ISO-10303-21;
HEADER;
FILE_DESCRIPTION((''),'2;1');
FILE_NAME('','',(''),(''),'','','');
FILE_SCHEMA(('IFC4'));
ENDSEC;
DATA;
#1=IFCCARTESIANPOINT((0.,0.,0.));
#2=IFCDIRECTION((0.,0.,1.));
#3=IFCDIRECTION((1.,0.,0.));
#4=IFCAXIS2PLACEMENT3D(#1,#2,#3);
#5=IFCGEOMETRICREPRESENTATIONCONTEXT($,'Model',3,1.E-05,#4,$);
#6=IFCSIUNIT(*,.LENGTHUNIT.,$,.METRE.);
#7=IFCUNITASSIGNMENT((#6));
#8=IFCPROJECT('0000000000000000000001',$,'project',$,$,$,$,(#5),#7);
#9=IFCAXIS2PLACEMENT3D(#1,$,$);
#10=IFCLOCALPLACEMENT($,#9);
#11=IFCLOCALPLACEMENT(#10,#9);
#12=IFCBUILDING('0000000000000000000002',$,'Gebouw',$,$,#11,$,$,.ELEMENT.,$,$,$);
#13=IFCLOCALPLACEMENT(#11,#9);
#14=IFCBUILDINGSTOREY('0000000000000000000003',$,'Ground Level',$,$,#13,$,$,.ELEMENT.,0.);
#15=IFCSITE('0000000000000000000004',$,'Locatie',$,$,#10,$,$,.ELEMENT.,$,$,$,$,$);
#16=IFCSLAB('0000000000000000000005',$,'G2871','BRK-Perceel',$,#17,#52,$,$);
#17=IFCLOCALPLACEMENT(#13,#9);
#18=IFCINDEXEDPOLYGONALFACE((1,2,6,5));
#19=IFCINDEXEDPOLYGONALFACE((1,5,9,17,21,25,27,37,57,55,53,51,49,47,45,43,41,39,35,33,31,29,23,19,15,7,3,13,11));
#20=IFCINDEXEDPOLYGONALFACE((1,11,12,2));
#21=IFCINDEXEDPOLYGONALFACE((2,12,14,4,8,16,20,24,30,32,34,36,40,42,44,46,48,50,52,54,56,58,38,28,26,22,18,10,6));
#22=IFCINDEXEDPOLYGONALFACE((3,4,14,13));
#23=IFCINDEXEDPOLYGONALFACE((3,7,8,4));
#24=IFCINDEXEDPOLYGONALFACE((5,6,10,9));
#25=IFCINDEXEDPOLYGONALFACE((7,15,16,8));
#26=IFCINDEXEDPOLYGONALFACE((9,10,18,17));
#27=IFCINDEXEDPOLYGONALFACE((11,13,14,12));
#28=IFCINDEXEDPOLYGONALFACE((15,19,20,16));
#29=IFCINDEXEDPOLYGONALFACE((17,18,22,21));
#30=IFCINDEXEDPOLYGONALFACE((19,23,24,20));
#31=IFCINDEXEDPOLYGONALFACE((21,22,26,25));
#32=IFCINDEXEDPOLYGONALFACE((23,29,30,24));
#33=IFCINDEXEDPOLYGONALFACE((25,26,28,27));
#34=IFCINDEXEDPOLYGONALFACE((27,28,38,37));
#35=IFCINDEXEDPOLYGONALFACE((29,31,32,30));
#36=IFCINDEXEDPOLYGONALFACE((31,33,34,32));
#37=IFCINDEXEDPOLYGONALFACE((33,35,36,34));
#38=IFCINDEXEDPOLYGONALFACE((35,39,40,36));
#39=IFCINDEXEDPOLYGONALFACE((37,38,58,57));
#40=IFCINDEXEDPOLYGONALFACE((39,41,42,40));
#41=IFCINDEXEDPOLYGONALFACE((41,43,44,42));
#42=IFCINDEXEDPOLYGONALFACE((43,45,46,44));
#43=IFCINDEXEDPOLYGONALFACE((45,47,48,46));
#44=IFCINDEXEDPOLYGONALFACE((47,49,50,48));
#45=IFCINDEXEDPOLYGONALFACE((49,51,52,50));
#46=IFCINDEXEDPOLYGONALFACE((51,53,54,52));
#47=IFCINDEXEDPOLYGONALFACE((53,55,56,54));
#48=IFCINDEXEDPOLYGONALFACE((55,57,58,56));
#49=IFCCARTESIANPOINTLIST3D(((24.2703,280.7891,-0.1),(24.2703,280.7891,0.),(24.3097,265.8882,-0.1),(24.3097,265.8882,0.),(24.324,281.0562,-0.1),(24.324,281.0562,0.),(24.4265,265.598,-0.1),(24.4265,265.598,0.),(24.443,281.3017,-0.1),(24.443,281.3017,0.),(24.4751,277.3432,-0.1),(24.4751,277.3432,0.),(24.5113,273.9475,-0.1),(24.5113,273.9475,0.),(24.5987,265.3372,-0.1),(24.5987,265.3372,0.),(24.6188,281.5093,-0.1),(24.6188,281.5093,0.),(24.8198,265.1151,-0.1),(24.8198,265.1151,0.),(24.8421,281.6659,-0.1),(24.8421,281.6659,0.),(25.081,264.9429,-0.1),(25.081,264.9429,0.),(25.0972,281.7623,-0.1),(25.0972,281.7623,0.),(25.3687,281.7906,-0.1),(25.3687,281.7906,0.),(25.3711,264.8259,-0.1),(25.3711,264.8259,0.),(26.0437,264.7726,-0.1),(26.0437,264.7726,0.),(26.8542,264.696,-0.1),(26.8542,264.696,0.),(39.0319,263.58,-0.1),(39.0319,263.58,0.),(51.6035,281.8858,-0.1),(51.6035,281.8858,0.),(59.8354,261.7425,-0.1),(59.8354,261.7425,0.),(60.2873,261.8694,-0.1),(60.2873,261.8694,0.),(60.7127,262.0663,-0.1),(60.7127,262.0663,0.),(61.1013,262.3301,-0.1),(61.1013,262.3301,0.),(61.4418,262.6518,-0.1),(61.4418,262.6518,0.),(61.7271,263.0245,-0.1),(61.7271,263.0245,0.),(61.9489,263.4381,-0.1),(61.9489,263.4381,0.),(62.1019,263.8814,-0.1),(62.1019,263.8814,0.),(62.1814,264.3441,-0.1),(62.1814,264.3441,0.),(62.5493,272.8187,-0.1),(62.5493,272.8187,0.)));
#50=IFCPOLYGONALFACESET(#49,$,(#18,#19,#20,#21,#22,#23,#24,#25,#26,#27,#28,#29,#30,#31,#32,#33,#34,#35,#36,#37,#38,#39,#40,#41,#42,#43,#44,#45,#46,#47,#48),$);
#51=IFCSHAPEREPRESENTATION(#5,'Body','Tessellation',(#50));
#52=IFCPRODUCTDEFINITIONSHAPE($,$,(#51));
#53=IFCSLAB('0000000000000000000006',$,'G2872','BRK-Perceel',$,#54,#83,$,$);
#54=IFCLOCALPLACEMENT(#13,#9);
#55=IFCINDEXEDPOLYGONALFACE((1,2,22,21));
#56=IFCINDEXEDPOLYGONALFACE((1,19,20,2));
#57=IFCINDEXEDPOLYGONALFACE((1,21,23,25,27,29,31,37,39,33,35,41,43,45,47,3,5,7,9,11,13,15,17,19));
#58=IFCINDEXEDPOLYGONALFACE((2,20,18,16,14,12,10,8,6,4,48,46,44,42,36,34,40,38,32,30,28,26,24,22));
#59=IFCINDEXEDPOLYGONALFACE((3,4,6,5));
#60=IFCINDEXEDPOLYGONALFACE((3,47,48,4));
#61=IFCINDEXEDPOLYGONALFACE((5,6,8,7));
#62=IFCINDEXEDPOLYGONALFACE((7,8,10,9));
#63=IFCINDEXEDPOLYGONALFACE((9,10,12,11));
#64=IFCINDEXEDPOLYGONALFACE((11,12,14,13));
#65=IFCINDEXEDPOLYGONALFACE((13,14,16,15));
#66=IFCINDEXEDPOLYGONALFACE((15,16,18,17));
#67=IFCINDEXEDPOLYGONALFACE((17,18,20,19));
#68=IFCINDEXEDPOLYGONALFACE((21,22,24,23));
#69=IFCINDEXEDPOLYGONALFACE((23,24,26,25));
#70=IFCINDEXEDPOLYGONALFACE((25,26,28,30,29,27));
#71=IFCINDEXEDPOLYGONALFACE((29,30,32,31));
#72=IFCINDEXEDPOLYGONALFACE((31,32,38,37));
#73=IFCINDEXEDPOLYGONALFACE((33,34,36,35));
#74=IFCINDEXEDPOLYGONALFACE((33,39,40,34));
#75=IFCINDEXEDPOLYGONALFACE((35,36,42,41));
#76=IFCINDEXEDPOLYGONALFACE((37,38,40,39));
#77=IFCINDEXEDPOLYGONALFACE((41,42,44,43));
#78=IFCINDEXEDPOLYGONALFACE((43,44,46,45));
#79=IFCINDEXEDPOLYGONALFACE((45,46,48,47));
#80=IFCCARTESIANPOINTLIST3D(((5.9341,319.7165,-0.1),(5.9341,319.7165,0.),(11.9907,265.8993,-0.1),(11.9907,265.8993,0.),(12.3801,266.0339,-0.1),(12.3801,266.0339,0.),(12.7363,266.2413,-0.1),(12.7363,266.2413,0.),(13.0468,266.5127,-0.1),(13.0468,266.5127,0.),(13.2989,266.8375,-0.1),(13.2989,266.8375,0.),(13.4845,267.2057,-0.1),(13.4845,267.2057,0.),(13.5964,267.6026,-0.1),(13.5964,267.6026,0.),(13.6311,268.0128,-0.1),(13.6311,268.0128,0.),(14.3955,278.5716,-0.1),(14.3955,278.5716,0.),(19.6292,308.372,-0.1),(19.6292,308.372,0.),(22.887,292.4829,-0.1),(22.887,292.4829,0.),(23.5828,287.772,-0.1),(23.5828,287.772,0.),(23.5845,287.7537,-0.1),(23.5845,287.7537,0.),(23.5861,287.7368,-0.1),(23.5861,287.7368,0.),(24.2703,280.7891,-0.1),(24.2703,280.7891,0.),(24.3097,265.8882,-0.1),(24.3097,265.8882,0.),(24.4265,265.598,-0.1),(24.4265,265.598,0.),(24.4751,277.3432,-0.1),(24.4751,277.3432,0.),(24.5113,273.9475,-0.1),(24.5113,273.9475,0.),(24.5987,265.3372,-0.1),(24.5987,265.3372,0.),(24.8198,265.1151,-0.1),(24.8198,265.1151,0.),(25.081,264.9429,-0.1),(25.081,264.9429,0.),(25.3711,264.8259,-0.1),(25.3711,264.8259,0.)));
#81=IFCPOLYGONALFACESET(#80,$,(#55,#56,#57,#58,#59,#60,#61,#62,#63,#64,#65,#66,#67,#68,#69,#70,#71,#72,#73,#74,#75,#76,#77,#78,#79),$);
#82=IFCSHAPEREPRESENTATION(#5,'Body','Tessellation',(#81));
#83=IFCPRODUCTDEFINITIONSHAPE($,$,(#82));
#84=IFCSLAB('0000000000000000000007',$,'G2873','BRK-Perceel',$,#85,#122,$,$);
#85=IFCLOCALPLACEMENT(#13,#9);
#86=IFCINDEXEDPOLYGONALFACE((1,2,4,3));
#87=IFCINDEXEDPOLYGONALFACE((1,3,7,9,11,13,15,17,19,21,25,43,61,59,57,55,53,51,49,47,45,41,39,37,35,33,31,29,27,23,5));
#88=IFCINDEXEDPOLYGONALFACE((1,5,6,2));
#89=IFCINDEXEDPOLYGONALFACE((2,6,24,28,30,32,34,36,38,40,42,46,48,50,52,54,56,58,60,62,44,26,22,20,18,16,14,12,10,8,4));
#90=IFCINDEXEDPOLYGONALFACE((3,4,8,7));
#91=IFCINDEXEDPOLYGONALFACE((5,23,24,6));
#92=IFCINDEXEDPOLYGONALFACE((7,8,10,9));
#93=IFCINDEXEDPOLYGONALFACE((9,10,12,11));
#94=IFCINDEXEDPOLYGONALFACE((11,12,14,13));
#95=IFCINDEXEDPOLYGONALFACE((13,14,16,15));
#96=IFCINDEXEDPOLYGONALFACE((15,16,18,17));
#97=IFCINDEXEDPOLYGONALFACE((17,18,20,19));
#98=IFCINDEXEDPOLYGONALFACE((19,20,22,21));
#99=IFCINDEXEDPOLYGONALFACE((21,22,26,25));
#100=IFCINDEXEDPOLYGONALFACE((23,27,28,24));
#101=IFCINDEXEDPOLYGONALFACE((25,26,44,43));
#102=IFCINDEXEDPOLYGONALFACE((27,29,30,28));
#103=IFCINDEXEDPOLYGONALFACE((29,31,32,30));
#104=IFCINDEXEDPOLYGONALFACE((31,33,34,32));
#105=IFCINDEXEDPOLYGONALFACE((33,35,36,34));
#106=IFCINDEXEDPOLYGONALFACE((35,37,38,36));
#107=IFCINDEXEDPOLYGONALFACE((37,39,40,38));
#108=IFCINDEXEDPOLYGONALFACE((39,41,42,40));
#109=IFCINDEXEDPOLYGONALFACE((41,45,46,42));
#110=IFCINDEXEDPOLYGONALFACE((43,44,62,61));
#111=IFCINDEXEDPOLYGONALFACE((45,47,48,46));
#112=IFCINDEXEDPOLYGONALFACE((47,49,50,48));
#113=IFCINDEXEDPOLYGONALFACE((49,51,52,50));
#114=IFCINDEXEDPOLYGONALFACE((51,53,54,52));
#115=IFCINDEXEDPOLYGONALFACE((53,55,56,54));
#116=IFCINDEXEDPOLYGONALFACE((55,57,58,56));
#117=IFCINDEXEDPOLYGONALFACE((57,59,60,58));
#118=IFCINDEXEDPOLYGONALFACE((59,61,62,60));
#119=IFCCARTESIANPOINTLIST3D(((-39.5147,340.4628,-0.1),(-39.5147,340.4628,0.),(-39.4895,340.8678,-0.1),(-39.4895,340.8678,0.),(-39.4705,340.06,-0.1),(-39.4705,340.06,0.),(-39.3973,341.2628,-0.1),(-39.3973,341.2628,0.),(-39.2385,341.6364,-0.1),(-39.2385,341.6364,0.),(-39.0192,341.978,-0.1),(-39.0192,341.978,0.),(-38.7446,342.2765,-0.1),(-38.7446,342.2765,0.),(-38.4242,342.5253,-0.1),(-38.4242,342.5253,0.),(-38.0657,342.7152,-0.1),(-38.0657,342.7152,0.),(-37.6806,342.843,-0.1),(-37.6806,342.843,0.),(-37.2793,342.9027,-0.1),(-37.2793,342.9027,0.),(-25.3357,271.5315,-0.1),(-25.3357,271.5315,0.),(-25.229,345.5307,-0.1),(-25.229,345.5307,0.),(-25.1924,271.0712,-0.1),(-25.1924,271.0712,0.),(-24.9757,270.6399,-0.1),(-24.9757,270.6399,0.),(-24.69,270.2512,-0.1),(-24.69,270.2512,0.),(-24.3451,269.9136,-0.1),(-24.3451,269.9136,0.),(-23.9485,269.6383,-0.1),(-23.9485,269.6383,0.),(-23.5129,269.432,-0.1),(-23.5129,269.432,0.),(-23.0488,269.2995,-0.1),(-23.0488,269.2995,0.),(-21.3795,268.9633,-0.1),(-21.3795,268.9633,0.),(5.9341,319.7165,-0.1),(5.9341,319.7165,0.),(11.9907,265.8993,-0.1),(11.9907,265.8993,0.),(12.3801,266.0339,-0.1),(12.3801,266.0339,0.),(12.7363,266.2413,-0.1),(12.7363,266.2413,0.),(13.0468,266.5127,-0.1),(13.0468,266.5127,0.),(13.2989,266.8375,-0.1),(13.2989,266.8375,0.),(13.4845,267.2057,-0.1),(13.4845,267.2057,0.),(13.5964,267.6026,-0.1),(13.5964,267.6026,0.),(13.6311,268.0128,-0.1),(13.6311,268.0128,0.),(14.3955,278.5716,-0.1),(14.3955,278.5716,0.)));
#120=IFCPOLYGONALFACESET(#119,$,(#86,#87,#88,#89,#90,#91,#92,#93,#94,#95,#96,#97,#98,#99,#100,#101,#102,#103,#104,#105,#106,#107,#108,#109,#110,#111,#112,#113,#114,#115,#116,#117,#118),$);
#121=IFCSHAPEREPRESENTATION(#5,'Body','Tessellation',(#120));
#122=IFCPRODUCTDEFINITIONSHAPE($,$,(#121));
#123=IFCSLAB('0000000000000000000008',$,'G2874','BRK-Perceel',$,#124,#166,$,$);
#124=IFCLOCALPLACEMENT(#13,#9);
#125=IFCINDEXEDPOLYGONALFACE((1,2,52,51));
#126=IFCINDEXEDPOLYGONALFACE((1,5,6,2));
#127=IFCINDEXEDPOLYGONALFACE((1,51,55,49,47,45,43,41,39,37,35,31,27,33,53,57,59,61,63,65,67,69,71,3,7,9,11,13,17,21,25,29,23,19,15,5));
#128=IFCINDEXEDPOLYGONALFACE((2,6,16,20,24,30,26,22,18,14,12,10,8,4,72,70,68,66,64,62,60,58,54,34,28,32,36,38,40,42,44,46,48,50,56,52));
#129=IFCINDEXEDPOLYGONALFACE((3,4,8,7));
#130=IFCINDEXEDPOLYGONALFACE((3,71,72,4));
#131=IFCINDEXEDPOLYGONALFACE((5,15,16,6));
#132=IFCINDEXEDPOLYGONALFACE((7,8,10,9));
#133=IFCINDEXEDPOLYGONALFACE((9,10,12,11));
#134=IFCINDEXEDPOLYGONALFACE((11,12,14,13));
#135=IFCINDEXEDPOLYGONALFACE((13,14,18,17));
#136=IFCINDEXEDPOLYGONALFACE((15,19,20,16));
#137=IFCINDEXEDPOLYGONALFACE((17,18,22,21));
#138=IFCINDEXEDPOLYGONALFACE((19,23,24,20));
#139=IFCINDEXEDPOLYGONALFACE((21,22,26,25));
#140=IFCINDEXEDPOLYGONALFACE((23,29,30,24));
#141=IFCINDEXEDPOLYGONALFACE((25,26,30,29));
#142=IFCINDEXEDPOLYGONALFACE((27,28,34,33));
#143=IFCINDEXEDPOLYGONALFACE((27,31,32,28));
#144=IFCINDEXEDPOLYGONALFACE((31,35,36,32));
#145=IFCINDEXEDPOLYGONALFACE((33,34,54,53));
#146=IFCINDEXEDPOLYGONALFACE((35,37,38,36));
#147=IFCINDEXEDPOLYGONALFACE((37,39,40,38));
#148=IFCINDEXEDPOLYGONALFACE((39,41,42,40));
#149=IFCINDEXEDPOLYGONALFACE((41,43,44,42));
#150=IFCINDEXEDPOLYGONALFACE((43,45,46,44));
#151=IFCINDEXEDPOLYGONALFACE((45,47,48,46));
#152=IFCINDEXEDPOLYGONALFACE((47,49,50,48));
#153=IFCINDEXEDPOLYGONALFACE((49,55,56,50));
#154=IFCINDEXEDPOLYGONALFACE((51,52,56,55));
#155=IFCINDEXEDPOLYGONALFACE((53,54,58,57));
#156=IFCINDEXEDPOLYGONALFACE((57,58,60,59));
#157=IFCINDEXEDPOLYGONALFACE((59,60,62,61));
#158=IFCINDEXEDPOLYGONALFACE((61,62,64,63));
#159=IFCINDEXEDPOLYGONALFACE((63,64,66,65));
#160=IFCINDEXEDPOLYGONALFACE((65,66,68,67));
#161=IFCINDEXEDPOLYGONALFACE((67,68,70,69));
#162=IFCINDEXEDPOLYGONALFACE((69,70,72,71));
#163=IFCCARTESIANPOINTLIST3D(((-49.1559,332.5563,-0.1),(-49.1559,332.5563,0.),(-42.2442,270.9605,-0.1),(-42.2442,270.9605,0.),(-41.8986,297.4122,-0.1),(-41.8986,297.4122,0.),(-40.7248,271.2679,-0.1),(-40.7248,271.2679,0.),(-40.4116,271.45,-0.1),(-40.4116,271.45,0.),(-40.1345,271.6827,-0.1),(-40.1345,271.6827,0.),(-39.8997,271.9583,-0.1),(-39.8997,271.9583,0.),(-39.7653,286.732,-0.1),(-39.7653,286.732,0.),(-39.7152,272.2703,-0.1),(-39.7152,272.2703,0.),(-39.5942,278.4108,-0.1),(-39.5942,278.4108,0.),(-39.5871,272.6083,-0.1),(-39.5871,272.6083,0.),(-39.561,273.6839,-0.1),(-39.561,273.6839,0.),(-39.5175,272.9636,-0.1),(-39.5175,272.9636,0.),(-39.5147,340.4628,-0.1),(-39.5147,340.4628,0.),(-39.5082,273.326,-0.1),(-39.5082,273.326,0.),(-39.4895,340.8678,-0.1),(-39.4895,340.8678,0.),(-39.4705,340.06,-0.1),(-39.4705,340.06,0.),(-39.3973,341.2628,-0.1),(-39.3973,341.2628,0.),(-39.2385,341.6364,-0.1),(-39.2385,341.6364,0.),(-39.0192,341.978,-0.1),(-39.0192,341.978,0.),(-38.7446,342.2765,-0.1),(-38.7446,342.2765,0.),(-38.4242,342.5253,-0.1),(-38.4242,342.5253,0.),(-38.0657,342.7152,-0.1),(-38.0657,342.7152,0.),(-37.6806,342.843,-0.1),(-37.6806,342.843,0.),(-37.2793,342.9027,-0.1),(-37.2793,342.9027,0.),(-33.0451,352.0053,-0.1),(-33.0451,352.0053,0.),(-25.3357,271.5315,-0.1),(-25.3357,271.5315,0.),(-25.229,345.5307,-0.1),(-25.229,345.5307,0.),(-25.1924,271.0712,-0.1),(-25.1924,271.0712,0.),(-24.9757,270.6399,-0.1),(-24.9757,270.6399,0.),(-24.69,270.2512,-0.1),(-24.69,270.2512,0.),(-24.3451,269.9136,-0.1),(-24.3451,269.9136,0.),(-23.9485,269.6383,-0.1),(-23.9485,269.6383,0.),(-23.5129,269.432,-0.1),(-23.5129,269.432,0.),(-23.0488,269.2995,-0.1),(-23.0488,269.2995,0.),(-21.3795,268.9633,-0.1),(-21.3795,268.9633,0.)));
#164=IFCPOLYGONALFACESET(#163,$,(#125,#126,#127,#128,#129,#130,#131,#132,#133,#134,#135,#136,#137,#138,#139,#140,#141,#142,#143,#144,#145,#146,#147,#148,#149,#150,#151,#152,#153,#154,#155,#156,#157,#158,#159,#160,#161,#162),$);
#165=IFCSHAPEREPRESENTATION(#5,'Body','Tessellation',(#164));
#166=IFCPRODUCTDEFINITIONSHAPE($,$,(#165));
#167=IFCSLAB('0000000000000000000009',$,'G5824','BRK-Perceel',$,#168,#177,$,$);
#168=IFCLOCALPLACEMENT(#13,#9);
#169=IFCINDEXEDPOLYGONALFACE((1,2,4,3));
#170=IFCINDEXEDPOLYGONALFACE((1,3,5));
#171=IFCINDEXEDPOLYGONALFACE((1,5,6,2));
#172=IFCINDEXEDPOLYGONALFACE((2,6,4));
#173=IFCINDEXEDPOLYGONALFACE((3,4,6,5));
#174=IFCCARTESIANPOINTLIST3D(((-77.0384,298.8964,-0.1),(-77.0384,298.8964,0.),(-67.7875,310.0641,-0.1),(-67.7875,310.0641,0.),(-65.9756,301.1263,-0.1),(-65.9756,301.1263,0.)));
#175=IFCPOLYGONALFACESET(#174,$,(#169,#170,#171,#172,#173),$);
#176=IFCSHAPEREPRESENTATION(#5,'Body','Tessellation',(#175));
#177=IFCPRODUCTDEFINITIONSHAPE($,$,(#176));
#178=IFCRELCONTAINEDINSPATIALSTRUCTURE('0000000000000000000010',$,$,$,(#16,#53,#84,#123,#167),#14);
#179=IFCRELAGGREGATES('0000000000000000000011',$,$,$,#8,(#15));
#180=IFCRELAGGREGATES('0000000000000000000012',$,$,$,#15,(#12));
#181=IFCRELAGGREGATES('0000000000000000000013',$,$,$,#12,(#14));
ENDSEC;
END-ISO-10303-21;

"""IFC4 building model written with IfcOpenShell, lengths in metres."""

from ifc_helpers import new_model, si_unit, frame, origin, origin_with_axes, place, context, project, spatial, polyline, outline, extrude, element, save


model = new_model("IFC4")

# Units and contexts
model_context = context("Model", 3, precision=1e-05, world=origin_with_axes())
ifc_project = project(units=[si_unit("LENGTHUNIT", "METRE")], contexts=[model_context])

# Site, building, storey
site_placement = place(None, origin())
site = spatial("IfcSite", under=ifc_project, at=site_placement, Name="Locatie", CompositionType="ELEMENT")
building_placement = place(site_placement, origin())
building = spatial("IfcBuilding", under=site, at=building_placement, Name="Gebouw", CompositionType="ELEMENT")
storey_placement = place(building_placement, origin())
storey = spatial("IfcBuildingStorey", under=building, at=storey_placement, Name="Ground Level", CompositionType="ELEMENT", Elevation=0.0)

# Slabs
slab_1_placement = place(storey_placement, origin())
element("IfcSlab", 1, at=slab_1_placement, inside=storey, Name="G2871", Description="BRK-Perceel", context=model_context, shape_type="SweptSolid", body=[
    extrude(outline(polyline([(62.1814, 264.3441), (62.1019, 263.8814), (61.9489, 263.4381), (61.7271, 263.0245), (61.4418, 262.6518), (61.1013, 262.3301), (60.7127, 262.0663), (60.2873, 261.8694), (59.8354, 261.7425), (39.0319, 263.58), (26.8542, 264.696), (26.0437, 264.7726), (25.3711, 264.8259), (25.081, 264.9429), (24.8198, 265.1151), (24.5987, 265.3372), (24.4265, 265.598), (24.3097, 265.8882), (24.5113, 273.9475), (24.4751, 277.3432), (24.2703, 280.7891), (24.324, 281.0562), (24.443, 281.3017), (24.6188, 281.5093), (24.8421, 281.6659), (25.0972, 281.7623), (25.3687, 281.7906), (51.6035, 281.8858), (62.5493, 272.8187), (62.1814, 264.3441)])), frame((0.0, 0.0, -0.1), z_axis=(0.0, 0.0, 1.0), x_axis=(1.0, 0.0, 0.0)), (0.0, 0.0, 1.0), 0.1),
])
slab_2_placement = place(storey_placement, origin())
element("IfcSlab", 2, at=slab_2_placement, inside=storey, Name="G2872", Description="BRK-Perceel", context=model_context, shape_type="SweptSolid", body=[
    extrude(outline(polyline([(22.887, 292.4829), (23.5828, 287.772), (23.5845, 287.7537), (23.5861, 287.7368), (24.2703, 280.7891), (24.4751, 277.3432), (24.5113, 273.9475), (24.3097, 265.8882), (24.4265, 265.598), (24.5987, 265.3372), (24.8198, 265.1151), (25.081, 264.9429), (25.3711, 264.8259), (11.9907, 265.8993), (12.3801, 266.0339), (12.7363, 266.2413), (13.0468, 266.5127), (13.2989, 266.8375), (13.4845, 267.2057), (13.5964, 267.6026), (13.6311, 268.0128), (14.3955, 278.5716), (5.9341, 319.7165), (19.6292, 308.372), (22.887, 292.4829)])), frame((0.0, 0.0, -0.1), z_axis=(0.0, 0.0, 1.0), x_axis=(1.0, 0.0, 0.0)), (0.0, 0.0, 1.0), 0.1),
])
slab_3_placement = place(storey_placement, origin())
element("IfcSlab", 3, at=slab_3_placement, inside=storey, Name="G2873", Description="BRK-Perceel", context=model_context, shape_type="SweptSolid", body=[
    extrude(outline(polyline([(14.3955, 278.5716), (13.6311, 268.0128), (13.5964, 267.6026), (13.4845, 267.2057), (13.2989, 266.8375), (13.0468, 266.5127), (12.7363, 266.2413), (12.3801, 266.0339), (11.9907, 265.8993), (-21.3795, 268.9633), (-23.0488, 269.2995), (-23.5129, 269.432), (-23.9485, 269.6383), (-24.3451, 269.9136), (-24.69, 270.2512), (-24.9757, 270.6399), (-25.1924, 271.0712), (-25.3357, 271.5315), (-39.4705, 340.06), (-39.5147, 340.4628), (-39.4895, 340.8678), (-39.3973, 341.2628), (-39.2385, 341.6364), (-39.0192, 341.978), (-38.7446, 342.2765), (-38.4242, 342.5253), (-38.0657, 342.7152), (-37.6806, 342.843), (-37.2793, 342.9027), (-25.229, 345.5307), (5.9341, 319.7165), (14.3955, 278.5716)])), frame((0.0, 0.0, -0.1), z_axis=(0.0, 0.0, 1.0), x_axis=(1.0, 0.0, 0.0)), (0.0, 0.0, 1.0), 0.1),
])
slab_4_placement = place(storey_placement, origin())
element("IfcSlab", 4, at=slab_4_placement, inside=storey, Name="G2874", Description="BRK-Perceel", context=model_context, shape_type="SweptSolid", body=[
    extrude(outline(polyline([(-37.2793, 342.9027), (-37.6806, 342.843), (-38.0657, 342.7152), (-38.4242, 342.5253), (-38.7446, 342.2765), (-39.0192, 341.978), (-39.2385, 341.6364), (-39.3973, 341.2628), (-39.4895, 340.8678), (-39.5147, 340.4628), (-39.4705, 340.06), (-25.3357, 271.5315), (-25.1924, 271.0712), (-24.9757, 270.6399), (-24.69, 270.2512), (-24.3451, 269.9136), (-23.9485, 269.6383), (-23.5129, 269.432), (-23.0488, 269.2995), (-21.3795, 268.9633), (-42.2442, 270.9605), (-40.7248, 271.2679), (-40.4116, 271.45), (-40.1345, 271.6827), (-39.8997, 271.9583), (-39.7152, 272.2703), (-39.5871, 272.6083), (-39.5175, 272.9636), (-39.5082, 273.326), (-39.561, 273.6839), (-39.5942, 278.4108), (-39.7653, 286.732), (-41.8986, 297.4122), (-49.1559, 332.5563), (-33.0451, 352.0053), (-25.229, 345.5307), (-37.2793, 342.9027)])), frame((0.0, 0.0, -0.1), z_axis=(0.0, 0.0, 1.0), x_axis=(1.0, 0.0, 0.0)), (0.0, 0.0, 1.0), 0.1),
])
slab_5_placement = place(storey_placement, origin())
element("IfcSlab", 5, at=slab_5_placement, inside=storey, Name="G5824", Description="BRK-Perceel", context=model_context, shape_type="SweptSolid", body=[
    extrude(outline(polyline([(-65.9756, 301.1263), (-77.0384, 298.8964), (-67.7875, 310.0641), (-65.9756, 301.1263)])), frame((0.0, 0.0, -0.1), z_axis=(0.0, 0.0, 1.0), x_axis=(1.0, 0.0, 0.0)), (0.0, 0.0, 1.0), 0.1),
])

save(model, "model.ifc")
